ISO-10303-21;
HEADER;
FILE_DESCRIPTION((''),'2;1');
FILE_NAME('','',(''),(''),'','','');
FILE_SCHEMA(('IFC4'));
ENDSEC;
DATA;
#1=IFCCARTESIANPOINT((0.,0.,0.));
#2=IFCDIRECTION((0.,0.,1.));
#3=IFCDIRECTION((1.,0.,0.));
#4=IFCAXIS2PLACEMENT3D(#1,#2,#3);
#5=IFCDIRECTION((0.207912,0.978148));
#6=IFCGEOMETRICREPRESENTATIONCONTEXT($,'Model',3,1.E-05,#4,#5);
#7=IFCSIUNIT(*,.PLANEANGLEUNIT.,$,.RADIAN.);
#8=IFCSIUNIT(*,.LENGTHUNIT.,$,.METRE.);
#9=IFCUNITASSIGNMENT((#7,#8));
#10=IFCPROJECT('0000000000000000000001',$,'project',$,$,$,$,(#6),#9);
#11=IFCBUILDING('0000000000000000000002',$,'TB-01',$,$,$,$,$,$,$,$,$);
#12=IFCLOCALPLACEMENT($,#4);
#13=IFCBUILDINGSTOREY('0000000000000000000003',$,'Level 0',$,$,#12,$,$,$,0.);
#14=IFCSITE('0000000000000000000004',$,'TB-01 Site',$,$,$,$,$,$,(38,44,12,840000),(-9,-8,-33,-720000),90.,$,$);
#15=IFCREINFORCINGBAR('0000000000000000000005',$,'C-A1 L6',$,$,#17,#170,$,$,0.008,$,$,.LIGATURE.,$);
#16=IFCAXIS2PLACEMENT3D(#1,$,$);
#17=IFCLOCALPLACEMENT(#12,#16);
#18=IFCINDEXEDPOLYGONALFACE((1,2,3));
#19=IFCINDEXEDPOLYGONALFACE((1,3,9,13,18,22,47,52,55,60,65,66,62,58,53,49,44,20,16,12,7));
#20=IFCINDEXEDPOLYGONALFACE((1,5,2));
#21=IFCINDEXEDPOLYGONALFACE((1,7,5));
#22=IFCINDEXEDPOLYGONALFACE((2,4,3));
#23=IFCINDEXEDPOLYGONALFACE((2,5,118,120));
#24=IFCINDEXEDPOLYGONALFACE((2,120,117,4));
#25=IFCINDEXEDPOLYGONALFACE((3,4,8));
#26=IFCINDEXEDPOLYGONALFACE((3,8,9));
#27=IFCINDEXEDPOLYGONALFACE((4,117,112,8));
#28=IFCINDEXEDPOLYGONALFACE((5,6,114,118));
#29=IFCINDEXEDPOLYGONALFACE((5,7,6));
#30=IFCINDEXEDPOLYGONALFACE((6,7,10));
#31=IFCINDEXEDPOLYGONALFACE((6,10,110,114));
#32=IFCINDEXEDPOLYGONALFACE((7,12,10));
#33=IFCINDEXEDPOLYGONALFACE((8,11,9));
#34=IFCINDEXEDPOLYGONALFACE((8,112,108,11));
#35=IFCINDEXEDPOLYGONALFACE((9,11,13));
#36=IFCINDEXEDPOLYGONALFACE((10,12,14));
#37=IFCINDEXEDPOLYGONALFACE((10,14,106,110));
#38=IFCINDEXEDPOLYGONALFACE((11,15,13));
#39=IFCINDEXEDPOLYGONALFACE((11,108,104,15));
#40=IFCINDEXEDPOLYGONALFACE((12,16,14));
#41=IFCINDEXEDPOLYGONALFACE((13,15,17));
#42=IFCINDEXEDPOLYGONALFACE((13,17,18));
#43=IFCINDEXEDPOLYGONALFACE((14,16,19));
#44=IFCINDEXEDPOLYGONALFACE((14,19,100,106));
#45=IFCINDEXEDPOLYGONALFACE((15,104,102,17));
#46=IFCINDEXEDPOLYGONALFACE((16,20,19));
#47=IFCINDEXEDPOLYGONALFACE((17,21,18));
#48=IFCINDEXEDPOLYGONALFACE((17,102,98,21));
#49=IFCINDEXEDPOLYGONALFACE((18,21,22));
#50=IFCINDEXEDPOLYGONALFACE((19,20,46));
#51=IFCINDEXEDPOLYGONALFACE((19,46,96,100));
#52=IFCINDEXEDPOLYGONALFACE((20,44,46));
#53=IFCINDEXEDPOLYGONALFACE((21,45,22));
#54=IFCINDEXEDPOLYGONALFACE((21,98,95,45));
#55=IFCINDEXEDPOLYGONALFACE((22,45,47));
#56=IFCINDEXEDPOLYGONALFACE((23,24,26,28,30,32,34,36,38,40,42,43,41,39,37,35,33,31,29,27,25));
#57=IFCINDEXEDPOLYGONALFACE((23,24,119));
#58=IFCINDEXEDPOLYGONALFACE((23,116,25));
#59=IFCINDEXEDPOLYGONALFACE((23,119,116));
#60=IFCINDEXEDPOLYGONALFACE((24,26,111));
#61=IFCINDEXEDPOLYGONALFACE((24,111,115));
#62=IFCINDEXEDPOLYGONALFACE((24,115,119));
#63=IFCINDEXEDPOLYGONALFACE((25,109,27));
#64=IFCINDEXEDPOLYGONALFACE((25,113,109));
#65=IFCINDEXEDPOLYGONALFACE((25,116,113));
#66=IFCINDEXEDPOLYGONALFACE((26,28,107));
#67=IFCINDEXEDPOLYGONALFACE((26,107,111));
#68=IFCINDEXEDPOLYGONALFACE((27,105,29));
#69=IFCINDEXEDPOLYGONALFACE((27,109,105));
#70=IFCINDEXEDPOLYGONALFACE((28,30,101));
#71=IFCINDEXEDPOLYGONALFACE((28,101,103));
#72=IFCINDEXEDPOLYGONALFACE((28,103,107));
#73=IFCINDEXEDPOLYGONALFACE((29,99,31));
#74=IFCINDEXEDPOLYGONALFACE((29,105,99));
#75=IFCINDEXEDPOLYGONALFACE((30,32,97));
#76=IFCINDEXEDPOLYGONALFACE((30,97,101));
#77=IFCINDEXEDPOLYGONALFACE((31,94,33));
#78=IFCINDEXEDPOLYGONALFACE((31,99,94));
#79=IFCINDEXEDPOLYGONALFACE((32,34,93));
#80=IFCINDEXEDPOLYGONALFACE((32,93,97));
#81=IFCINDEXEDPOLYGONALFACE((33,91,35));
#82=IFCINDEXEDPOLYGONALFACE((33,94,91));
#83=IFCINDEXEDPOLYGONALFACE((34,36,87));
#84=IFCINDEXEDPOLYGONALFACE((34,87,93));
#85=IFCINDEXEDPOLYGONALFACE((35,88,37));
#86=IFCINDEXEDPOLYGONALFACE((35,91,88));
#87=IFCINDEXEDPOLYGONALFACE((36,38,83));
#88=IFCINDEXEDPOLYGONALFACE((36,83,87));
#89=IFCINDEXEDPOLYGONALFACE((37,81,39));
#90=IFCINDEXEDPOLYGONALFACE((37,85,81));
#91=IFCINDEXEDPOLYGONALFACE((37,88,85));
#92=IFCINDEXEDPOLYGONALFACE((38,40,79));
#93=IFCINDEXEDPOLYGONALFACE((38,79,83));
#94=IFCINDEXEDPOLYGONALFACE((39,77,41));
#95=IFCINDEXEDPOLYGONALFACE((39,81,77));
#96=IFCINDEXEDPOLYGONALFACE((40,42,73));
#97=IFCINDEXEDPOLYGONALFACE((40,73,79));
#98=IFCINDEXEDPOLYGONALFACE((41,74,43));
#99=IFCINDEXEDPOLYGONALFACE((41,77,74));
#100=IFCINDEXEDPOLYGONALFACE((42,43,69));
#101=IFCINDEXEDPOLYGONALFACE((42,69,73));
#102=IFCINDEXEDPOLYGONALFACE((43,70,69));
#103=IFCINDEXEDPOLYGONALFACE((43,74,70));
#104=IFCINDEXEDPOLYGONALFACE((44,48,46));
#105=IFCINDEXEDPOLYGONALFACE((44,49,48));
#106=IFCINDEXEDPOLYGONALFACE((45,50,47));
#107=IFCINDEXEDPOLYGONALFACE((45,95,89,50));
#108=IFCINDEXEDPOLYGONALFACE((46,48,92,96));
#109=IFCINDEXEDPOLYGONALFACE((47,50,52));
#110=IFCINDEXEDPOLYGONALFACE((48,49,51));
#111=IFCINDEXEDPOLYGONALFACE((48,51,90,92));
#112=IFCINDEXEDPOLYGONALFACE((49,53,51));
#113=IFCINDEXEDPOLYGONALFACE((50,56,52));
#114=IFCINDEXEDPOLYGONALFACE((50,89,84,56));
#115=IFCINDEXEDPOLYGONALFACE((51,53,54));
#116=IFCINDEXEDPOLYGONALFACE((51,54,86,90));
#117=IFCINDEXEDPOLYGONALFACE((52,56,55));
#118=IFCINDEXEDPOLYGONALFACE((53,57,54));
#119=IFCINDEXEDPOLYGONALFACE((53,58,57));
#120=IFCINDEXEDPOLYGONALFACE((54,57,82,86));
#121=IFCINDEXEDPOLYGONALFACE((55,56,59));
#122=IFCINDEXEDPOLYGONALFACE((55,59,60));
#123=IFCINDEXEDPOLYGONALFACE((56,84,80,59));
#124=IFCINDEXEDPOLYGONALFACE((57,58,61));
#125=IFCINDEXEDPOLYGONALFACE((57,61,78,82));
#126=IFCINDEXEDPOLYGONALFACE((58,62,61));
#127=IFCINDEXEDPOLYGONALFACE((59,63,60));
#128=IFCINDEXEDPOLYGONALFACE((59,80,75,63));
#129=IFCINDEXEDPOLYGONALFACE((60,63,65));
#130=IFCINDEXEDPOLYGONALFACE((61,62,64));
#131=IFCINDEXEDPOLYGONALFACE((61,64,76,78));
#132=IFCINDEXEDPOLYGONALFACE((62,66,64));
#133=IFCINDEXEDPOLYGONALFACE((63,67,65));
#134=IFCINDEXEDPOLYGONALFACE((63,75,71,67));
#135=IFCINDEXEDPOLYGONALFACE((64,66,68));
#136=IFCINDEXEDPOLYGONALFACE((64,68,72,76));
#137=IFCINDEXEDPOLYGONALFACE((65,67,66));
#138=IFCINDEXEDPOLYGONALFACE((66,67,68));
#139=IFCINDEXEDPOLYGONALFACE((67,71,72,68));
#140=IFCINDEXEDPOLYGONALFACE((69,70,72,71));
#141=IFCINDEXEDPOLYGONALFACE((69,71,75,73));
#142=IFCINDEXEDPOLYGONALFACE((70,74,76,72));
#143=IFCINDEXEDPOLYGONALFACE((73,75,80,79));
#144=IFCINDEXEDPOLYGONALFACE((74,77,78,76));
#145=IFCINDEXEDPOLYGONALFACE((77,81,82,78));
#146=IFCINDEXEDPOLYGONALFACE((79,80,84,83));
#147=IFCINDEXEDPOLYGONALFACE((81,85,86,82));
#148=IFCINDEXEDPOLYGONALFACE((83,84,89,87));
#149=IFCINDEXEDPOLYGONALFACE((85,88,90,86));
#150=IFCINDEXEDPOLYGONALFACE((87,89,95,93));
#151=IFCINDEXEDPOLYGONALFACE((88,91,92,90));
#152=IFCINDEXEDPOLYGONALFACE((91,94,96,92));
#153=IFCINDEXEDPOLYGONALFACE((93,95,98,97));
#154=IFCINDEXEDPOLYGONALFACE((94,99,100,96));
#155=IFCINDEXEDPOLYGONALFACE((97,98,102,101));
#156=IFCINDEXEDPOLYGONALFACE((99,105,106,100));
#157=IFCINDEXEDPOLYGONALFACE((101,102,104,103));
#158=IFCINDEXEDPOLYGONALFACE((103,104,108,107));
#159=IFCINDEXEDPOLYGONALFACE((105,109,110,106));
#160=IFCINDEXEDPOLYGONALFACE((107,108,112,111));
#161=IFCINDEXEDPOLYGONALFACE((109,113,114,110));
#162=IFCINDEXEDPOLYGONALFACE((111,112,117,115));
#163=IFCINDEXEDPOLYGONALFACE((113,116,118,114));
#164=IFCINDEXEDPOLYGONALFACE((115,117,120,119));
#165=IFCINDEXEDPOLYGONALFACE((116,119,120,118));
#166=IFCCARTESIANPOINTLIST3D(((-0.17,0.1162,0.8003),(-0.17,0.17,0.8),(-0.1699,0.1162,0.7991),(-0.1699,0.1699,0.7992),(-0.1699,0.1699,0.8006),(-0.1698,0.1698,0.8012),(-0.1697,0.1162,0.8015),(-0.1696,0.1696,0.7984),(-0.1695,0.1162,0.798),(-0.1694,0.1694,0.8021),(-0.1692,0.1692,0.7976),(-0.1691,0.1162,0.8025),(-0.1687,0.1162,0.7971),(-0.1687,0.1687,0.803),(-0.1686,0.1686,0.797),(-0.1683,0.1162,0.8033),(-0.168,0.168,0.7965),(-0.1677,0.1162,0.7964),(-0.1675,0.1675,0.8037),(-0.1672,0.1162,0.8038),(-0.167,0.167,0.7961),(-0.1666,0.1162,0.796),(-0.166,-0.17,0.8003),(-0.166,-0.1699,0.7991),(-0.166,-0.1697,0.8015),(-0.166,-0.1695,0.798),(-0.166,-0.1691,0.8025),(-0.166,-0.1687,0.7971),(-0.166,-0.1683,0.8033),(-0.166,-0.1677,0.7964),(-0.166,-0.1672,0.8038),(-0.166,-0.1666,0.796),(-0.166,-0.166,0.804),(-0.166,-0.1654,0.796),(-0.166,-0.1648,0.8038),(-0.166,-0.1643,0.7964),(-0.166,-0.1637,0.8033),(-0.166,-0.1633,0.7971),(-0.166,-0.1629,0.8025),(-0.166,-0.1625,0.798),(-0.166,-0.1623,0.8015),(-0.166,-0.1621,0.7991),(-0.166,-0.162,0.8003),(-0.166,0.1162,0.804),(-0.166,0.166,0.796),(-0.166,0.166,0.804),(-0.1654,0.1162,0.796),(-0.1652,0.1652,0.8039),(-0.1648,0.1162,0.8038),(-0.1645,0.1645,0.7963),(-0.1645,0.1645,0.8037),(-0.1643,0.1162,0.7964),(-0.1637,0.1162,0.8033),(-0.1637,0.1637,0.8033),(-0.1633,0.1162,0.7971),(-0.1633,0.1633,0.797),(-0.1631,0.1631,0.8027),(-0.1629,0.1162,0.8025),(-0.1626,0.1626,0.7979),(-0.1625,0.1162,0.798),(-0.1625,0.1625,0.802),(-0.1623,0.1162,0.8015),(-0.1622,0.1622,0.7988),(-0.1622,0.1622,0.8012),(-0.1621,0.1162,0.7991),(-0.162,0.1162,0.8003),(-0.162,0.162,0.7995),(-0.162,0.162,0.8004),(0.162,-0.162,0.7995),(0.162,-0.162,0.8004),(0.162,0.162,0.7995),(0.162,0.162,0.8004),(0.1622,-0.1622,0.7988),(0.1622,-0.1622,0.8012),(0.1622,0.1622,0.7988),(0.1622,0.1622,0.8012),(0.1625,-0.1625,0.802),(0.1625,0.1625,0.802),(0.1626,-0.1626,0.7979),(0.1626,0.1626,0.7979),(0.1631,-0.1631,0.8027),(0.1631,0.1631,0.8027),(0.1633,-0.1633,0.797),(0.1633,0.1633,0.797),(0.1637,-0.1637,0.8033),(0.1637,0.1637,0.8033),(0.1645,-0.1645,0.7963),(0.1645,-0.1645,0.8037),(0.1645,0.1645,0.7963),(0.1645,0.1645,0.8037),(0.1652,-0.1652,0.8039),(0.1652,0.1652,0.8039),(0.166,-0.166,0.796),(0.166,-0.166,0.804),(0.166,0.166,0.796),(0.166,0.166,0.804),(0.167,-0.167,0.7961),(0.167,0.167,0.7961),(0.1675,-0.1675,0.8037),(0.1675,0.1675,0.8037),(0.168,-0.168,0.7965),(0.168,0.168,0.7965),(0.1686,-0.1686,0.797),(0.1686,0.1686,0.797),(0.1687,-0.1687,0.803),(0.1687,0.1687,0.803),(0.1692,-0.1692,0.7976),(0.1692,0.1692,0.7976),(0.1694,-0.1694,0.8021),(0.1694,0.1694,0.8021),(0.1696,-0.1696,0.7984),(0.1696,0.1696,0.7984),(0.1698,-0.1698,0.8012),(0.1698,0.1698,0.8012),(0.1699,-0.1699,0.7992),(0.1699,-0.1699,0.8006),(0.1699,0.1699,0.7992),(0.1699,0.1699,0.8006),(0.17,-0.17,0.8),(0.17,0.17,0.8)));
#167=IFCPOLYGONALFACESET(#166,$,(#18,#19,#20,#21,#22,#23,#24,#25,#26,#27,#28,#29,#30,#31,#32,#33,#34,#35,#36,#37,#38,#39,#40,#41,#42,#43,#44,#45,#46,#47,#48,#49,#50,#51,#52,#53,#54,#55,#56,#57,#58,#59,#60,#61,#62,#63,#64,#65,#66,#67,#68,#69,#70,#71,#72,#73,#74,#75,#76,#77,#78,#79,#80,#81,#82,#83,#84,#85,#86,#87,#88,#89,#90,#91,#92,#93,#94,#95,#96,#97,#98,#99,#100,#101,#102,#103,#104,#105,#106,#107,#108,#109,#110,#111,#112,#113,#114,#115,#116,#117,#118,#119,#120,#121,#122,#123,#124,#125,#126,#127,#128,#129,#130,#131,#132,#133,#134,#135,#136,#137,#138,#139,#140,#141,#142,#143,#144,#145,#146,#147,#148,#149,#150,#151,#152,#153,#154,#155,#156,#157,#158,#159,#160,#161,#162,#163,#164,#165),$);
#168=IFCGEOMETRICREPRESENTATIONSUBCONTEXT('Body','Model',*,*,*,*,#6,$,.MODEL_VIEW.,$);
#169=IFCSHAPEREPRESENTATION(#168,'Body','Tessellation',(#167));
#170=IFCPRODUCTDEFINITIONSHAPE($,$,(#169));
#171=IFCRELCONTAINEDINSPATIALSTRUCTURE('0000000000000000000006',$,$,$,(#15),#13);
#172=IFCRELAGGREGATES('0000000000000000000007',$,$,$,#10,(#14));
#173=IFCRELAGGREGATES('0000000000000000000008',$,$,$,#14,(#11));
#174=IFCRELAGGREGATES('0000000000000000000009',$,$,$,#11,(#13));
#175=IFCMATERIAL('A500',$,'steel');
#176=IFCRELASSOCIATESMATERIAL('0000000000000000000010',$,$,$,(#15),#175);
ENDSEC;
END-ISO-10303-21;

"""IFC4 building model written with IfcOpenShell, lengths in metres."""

from ifc_helpers import new_model, entity, si_unit, direction, origin_with_axes, place, context, subcontext, project, spatial, material, element, save


model = new_model("IFC4")

# Units and contexts
model_context = context("Model", 3, precision=1e-05, world=origin_with_axes(), true_north=direction((0.207912, 0.978148)))
body_context = subcontext(model_context, "Body", "Model", "MODEL_VIEW")
ifc_project = project(units=[si_unit("PLANEANGLEUNIT", "RADIAN"), si_unit("LENGTHUNIT", "METRE")], contexts=[model_context])

# Site, building, storey
site = spatial("IfcSite", under=ifc_project, Name="TB-01 Site", RefLatitude=(38, 44, 12, 840000), RefLongitude=(-9, -8, -33, -720000), RefElevation=90.0)
building = spatial("IfcBuilding", under=site, Name="TB-01")
storey_placement = place(None, origin_with_axes())
storey = spatial("IfcBuildingStorey", under=building, at=storey_placement, Name="Level 0", Elevation=0.0)

# Reinforcing bar
ifc_material_1 = material(Name="A500", Category="steel")
reinforcing_bar_1_placement = place(storey_placement, origin_with_axes())
element("IfcReinforcingBar", 1, at=reinforcing_bar_1_placement, inside=storey, material=ifc_material_1, Name="C-A1 L6", NominalDiameter=0.008, PredefinedType="LIGATURE", context=body_context, shape_type="AdvancedSweptSolid", body=[
    entity("IfcSweptDiskSolid", entity("IfcPolyline", [entity("IfcCartesianPoint", [-0.166, -0.166, 0.8]), entity("IfcCartesianPoint", [0.166, -0.166, 0.8]), entity("IfcCartesianPoint", [0.166, 0.166, 0.8]), entity("IfcCartesianPoint", [-0.166, 0.166, 0.8]), entity("IfcCartesianPoint", [-0.166, 0.1162, 0.8])]), 0.004),
])

save(model, "model.ifc")
